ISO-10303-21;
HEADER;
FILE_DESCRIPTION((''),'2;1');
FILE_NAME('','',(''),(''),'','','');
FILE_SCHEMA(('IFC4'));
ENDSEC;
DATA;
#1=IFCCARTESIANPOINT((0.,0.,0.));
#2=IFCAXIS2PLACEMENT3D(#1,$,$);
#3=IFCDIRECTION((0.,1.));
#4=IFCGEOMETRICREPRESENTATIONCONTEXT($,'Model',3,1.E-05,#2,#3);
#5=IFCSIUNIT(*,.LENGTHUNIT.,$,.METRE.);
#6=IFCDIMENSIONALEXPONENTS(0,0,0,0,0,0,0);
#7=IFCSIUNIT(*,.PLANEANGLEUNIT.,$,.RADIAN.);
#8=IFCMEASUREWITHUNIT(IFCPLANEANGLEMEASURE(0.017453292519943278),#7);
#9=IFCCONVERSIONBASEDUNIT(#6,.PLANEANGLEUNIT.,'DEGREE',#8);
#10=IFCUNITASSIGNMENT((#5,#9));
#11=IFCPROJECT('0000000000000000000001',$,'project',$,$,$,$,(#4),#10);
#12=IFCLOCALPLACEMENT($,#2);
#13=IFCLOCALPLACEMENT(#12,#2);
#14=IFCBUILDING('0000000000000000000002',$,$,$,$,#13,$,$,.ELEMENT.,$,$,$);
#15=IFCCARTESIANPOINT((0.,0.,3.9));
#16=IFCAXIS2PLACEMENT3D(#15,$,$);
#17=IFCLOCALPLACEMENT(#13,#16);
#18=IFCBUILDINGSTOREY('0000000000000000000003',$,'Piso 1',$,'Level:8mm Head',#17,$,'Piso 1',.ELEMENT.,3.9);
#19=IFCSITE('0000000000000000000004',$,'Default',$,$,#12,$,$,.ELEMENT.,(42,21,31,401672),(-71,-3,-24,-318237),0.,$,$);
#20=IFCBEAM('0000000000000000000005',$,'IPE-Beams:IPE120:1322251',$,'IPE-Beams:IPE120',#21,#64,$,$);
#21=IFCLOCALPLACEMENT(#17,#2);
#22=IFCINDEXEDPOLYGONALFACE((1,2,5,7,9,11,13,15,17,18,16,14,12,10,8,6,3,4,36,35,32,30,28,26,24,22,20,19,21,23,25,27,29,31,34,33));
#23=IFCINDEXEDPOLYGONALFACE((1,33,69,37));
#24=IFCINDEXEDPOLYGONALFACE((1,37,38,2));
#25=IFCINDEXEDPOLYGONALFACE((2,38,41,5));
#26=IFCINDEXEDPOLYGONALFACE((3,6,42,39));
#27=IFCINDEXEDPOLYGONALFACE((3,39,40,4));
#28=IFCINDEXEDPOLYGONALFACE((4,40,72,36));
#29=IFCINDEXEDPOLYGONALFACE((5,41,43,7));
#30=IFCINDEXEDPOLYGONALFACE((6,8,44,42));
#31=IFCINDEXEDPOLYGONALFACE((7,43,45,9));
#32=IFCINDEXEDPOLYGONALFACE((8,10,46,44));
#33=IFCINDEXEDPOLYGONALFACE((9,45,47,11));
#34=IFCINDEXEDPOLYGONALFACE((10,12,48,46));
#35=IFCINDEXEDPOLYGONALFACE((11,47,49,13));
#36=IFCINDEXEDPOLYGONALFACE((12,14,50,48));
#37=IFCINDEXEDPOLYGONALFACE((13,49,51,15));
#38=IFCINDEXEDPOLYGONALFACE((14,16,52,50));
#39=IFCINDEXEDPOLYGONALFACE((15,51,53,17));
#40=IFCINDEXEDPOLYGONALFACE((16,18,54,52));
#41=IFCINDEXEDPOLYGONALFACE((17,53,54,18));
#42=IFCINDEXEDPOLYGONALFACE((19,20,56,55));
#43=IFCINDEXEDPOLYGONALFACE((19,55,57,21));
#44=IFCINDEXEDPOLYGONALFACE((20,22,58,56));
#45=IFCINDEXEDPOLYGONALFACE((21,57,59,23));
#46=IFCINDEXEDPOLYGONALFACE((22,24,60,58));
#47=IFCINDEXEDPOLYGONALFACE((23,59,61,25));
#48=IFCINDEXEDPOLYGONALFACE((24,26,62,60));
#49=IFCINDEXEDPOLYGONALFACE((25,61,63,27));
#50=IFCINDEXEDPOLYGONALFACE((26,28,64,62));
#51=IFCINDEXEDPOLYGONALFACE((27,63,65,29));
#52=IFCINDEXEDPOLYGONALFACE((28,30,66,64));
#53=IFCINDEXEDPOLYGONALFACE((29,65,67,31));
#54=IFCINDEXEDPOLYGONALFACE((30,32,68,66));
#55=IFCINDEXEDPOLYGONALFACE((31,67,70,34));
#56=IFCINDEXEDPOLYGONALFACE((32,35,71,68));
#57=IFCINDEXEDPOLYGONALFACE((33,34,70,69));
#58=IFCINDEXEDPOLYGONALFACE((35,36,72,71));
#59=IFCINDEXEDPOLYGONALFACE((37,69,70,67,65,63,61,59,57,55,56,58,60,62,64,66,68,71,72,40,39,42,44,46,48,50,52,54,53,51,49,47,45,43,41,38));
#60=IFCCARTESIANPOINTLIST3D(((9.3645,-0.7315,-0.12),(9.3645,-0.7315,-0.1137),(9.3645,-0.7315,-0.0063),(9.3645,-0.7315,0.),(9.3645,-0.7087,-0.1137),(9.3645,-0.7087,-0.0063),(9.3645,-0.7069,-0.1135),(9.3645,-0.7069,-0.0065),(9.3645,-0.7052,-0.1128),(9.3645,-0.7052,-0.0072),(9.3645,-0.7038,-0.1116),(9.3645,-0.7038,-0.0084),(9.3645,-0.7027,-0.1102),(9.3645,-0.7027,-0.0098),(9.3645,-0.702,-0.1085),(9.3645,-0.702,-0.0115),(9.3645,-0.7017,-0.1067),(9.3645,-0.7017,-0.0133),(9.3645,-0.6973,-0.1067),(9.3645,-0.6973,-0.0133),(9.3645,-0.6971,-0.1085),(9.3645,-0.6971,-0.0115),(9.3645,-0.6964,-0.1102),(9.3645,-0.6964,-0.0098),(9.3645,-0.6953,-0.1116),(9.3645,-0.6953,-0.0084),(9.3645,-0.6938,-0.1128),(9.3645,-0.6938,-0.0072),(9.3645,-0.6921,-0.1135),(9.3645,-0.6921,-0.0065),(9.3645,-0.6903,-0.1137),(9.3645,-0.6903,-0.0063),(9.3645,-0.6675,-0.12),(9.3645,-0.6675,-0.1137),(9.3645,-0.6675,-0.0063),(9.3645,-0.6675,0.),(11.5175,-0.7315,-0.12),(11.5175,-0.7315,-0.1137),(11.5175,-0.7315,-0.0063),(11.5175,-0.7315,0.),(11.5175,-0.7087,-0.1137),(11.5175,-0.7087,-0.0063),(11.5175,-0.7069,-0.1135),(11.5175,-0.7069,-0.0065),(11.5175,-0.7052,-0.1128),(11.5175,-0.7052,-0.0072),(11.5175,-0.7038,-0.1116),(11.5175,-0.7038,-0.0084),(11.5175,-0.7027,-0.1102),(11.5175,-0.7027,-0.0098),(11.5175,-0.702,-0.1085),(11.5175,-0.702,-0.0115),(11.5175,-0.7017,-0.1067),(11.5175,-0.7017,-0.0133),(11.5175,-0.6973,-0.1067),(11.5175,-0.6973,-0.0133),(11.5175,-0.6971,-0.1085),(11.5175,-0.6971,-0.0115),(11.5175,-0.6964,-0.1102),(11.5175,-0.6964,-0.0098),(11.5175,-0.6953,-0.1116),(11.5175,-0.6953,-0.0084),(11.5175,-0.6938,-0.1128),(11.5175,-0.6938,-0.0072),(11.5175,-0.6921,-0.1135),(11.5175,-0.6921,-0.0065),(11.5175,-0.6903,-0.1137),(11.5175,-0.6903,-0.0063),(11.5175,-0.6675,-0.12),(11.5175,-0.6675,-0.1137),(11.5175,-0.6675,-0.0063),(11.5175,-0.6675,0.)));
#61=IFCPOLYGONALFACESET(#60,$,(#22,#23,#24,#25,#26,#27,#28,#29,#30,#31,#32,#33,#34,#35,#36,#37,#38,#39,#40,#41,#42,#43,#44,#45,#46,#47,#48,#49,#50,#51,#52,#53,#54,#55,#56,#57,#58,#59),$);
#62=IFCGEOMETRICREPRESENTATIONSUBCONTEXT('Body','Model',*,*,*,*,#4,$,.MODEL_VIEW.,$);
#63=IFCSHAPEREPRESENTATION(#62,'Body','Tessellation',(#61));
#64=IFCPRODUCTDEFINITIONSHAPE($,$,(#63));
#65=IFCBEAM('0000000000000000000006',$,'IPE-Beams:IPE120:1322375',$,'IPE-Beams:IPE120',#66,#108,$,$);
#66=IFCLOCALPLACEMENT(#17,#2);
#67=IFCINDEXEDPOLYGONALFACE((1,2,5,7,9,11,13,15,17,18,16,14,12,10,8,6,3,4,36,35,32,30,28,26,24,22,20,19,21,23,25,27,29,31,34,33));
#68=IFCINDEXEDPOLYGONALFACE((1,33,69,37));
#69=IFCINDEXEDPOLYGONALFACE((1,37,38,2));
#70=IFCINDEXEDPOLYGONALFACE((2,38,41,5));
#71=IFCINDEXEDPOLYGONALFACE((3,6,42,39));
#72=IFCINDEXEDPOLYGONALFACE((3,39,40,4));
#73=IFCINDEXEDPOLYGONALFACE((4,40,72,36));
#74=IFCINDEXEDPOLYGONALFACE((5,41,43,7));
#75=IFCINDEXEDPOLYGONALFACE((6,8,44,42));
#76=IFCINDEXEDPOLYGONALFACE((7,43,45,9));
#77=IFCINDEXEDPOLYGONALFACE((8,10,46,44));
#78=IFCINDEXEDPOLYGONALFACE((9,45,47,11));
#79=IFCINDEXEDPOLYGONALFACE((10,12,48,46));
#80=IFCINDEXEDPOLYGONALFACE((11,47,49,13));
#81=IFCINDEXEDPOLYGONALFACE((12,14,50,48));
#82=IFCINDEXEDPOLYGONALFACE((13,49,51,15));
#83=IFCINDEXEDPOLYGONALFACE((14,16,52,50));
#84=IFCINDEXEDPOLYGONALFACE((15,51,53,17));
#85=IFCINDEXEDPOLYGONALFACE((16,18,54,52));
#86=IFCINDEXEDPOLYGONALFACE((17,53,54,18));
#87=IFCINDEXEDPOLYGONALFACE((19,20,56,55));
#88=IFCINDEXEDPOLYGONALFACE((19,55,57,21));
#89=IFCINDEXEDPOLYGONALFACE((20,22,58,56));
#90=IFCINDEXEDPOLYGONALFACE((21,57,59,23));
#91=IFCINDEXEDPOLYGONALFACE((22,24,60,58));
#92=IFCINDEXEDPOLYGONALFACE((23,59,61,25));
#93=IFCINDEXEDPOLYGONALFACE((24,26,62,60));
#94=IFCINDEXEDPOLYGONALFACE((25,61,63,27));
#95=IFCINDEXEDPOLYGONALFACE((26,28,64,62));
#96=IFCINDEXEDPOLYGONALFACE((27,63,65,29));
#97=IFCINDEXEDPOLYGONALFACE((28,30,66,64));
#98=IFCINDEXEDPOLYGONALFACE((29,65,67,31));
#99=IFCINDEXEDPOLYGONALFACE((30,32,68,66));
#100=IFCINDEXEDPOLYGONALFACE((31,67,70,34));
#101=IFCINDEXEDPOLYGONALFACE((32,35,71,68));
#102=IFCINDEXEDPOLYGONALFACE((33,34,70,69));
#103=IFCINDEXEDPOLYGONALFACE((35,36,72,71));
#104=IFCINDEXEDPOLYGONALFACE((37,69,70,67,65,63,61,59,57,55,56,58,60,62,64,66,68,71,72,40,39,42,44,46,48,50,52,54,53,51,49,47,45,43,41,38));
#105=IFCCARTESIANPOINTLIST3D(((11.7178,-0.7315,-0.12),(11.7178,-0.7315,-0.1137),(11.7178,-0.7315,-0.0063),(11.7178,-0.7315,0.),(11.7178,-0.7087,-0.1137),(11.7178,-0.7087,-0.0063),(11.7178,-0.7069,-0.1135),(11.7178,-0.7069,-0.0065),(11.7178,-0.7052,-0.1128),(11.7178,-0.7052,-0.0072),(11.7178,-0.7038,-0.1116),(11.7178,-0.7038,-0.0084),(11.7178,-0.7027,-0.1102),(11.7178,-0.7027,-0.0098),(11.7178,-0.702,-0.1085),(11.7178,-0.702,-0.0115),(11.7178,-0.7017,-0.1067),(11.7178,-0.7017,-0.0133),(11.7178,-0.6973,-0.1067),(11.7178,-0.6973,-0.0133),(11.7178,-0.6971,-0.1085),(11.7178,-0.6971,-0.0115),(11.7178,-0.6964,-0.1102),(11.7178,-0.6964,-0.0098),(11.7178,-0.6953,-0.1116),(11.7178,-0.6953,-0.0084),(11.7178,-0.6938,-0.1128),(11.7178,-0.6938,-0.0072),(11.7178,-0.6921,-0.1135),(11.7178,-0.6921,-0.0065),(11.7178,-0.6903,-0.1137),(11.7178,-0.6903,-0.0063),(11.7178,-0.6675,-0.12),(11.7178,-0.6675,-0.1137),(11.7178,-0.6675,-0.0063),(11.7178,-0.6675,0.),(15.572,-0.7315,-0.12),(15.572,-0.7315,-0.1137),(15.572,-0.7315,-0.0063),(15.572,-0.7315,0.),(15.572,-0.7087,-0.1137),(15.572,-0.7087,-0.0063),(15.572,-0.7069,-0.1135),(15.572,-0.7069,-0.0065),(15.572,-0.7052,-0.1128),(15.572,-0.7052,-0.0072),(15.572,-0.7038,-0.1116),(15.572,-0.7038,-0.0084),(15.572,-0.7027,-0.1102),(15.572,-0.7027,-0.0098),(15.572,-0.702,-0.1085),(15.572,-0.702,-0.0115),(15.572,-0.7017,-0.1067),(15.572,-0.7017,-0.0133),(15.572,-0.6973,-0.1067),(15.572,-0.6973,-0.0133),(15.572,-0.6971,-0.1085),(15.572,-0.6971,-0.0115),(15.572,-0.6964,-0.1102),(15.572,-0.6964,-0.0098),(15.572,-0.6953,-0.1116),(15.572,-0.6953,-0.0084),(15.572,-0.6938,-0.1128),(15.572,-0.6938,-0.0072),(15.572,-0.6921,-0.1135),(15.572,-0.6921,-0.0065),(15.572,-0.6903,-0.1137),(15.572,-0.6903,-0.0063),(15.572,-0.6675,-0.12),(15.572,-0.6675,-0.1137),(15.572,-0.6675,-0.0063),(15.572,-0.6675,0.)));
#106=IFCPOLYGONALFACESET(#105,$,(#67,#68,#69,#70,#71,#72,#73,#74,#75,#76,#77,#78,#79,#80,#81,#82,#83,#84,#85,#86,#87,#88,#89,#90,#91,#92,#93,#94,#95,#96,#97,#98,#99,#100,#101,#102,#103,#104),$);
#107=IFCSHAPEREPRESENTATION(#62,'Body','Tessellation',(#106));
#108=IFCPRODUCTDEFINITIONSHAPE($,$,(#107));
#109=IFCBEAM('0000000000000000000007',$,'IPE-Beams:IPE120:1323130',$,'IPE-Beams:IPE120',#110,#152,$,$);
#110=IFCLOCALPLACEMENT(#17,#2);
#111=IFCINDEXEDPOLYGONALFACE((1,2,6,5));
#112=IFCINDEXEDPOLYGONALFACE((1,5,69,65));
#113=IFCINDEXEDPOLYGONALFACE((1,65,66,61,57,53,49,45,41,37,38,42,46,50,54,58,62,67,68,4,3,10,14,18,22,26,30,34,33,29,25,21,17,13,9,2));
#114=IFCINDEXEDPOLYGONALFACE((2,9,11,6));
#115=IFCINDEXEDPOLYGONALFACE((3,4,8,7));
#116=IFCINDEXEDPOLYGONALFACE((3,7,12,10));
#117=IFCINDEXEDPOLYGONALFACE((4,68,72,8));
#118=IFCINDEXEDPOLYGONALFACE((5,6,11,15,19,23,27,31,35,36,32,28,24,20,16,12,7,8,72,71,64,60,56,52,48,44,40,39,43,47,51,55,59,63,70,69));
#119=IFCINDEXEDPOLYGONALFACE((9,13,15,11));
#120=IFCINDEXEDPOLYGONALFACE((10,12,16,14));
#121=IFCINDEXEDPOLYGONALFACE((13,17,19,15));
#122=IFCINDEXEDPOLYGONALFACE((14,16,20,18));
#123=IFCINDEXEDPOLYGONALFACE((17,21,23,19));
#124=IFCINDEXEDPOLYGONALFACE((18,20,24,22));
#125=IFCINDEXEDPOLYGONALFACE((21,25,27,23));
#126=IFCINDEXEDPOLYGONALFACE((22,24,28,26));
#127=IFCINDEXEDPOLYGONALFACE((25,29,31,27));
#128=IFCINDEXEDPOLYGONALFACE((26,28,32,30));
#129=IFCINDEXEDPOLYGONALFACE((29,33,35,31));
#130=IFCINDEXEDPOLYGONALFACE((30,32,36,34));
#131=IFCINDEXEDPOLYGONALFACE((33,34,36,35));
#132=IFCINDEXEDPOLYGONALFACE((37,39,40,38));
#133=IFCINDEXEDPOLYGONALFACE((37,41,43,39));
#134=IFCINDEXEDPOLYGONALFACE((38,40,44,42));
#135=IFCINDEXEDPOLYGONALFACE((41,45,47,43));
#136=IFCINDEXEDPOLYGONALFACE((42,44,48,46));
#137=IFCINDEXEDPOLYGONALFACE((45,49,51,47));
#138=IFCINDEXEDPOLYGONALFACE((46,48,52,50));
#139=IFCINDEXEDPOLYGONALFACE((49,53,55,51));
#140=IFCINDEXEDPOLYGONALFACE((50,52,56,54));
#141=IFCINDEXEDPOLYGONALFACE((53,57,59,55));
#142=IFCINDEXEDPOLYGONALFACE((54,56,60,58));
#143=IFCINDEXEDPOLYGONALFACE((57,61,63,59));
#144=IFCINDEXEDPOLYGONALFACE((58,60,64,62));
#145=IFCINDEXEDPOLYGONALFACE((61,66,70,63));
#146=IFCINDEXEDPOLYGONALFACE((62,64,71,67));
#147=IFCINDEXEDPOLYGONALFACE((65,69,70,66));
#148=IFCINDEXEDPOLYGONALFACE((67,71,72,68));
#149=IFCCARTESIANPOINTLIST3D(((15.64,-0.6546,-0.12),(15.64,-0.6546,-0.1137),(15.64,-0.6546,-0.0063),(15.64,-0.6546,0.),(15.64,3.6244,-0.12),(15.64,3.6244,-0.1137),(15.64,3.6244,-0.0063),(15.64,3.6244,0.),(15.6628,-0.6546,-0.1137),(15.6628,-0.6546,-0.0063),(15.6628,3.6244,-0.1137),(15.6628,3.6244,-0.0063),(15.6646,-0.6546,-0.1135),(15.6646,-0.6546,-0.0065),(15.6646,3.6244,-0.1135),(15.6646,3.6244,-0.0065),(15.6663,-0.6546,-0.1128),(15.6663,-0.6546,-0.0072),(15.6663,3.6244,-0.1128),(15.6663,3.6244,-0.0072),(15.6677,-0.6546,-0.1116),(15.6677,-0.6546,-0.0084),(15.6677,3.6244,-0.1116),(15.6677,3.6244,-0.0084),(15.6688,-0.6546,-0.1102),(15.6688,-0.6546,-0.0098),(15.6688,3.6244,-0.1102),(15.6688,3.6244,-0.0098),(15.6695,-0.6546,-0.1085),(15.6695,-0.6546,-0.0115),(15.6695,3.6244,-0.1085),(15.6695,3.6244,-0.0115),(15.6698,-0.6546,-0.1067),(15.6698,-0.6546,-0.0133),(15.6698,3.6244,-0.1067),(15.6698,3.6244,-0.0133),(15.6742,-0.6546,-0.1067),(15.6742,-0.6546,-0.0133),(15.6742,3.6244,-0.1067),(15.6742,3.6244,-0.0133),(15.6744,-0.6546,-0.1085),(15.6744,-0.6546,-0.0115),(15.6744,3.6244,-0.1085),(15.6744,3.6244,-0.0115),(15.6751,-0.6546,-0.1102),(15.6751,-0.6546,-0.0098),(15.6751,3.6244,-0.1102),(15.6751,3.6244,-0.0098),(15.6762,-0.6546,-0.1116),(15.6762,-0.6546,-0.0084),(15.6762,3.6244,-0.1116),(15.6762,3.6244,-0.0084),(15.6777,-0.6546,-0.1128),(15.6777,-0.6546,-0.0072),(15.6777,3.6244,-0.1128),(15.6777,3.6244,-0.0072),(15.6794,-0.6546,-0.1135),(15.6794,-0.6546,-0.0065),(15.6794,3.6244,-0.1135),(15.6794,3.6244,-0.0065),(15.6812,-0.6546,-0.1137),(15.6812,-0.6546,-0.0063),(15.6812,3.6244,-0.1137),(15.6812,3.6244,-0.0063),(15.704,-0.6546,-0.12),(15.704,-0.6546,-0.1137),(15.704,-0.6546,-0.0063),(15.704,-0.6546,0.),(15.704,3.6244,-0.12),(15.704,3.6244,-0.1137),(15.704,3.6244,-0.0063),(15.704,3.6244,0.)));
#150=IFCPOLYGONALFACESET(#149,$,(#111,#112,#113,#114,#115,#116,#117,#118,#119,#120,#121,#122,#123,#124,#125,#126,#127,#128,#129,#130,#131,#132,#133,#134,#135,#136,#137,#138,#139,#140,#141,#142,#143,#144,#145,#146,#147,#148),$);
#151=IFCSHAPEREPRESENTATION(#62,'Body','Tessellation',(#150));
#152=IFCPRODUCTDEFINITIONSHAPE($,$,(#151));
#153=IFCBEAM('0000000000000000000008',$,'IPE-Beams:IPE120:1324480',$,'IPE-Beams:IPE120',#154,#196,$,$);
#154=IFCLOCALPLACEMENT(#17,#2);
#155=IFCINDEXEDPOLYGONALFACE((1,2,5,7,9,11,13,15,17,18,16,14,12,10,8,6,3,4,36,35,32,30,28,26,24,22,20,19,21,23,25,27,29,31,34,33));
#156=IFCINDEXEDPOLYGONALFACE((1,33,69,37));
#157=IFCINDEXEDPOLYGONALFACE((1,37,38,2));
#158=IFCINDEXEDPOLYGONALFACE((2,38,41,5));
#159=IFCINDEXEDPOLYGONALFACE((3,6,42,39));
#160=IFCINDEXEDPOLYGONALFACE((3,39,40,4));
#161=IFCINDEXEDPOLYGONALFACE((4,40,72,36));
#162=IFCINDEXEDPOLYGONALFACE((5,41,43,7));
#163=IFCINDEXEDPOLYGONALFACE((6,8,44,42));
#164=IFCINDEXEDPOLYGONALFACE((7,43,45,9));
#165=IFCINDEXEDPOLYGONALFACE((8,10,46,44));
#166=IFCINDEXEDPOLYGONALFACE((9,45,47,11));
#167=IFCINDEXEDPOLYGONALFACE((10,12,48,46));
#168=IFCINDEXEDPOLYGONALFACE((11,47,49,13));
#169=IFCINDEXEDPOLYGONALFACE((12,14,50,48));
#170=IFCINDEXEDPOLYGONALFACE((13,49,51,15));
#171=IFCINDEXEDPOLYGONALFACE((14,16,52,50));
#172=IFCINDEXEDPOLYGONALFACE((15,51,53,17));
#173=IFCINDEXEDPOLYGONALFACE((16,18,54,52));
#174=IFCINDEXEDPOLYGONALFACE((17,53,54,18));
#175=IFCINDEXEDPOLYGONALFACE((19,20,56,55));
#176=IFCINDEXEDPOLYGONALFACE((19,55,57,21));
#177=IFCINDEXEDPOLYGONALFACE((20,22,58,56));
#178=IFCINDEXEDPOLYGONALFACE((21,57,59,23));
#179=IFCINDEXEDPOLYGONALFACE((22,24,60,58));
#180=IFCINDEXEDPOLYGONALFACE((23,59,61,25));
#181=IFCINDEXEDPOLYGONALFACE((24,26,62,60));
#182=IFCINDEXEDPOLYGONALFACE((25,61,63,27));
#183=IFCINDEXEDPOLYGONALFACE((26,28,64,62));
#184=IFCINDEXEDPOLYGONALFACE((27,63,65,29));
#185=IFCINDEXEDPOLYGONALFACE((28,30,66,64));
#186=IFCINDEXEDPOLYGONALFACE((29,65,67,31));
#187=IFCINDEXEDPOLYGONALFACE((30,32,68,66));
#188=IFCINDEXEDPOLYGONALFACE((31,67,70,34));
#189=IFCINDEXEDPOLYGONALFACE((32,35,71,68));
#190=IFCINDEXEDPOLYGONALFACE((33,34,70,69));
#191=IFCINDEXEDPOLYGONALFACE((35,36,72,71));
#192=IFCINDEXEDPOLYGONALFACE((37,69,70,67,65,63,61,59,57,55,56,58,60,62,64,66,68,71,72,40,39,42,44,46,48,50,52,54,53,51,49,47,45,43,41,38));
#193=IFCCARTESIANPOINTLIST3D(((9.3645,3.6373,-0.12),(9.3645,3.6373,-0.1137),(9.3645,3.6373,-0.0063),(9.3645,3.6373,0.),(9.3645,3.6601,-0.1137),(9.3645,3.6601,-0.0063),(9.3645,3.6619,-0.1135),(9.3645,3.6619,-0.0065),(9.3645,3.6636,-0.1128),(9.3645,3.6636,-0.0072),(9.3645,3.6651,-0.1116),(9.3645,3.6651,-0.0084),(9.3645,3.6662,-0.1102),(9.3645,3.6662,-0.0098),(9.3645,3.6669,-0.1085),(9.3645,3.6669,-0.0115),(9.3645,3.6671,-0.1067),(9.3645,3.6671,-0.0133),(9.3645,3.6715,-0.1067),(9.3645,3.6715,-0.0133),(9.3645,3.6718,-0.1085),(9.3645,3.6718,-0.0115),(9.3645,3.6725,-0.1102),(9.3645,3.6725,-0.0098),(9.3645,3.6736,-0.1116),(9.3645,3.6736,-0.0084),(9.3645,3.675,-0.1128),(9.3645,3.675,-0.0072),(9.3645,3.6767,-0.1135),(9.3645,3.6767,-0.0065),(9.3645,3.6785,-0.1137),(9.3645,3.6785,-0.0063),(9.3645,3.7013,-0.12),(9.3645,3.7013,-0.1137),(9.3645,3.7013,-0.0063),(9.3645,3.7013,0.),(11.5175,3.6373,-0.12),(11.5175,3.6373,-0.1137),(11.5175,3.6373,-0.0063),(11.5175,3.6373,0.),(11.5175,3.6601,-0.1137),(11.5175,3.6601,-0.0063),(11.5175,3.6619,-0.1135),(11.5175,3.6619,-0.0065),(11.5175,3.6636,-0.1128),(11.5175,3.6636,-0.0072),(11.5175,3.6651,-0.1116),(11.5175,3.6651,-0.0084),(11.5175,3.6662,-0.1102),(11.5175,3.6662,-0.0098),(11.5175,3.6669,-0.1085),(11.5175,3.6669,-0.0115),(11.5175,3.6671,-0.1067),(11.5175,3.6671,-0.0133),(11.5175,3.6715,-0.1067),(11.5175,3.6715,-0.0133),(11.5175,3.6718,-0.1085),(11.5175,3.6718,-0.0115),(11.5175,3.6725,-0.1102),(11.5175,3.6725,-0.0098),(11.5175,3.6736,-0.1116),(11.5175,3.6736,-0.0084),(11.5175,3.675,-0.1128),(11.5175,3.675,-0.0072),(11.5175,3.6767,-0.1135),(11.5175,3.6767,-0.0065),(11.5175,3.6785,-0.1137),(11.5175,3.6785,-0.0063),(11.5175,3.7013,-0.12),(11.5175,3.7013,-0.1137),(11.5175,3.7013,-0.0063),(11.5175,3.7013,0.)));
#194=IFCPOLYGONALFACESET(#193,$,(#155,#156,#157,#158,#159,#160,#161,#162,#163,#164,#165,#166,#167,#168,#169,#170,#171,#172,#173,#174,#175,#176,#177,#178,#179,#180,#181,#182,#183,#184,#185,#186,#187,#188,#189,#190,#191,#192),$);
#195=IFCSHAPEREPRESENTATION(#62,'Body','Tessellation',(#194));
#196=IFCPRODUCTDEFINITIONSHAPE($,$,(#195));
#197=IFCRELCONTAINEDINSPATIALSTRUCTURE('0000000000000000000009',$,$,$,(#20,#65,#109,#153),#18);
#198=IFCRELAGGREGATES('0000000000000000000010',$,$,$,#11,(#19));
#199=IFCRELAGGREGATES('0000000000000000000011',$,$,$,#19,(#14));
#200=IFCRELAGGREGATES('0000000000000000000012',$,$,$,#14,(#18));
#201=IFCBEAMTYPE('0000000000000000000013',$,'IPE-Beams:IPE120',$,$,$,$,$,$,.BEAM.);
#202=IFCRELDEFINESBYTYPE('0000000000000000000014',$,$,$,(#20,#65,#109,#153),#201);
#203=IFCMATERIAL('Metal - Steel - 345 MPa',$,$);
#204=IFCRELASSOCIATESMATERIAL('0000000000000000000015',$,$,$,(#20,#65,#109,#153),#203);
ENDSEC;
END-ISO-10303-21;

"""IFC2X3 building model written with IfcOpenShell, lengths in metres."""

from ifc_helpers import new_model, entity, si_unit, converted_unit, direction, frame, frame_2d, origin, place, context, subcontext, project, spatial, i_section, extrude, material, type_object, element, save


model = new_model("IFC2X3")

# Units and contexts
model_context = context("Model", 3, precision=1e-05, world=origin(), true_north=direction((0.0, 1.0)))
body_context = subcontext(model_context, "Body", "Model", "MODEL_VIEW")
ifc_project = project(units=[si_unit("LENGTHUNIT", "METRE"), converted_unit("PLANEANGLEUNIT", "DEGREE", entity("IfcPlaneAngleMeasure", 0.017453292519943278), si_unit("PLANEANGLEUNIT", "RADIAN"), dimensions=[0, 0, 0, 0, 0, 0, 0])], contexts=[model_context])

# Site, building, storey
site_placement = place(None, origin())
site = spatial("IfcSite", under=ifc_project, at=site_placement, Name="Default", CompositionType="ELEMENT", RefLatitude=(42, 21, 31, 401672), RefLongitude=(-71, -3, -24, -318237), RefElevation=0.0)
building_placement = place(site_placement, origin())
building = spatial("IfcBuilding", under=site, at=building_placement, CompositionType="ELEMENT")
storey_placement = place(building_placement, frame((0.0, 0.0, 3.9)))
storey = spatial("IfcBuildingStorey", under=building, at=storey_placement, Name="Piso 1", ObjectType="Level:8mm Head", LongName="Piso 1", CompositionType="ELEMENT", Elevation=3.9)

# Beams
ifc_material = material(Name="Metal - Steel - 345 MPa")
beam_type_1 = type_object("IfcBeamType", Name="IPE-Beams:IPE120", PredefinedType="BEAM")
beam_1_placement = place(storey_placement, frame((11.6176, -0.6995, 0.0), z_axis=(0.0, 0.0, 1.0), x_axis=(-1.0, 0.0, 0.0)))
element("IfcBeam", 1, at=beam_1_placement, inside=storey, type_object=beam_type_1, material=ifc_material, Name="IPE-Beams:IPE120:1322251", ObjectType="IPE-Beams:IPE120", context=body_context, shape_type="SweptSolid", body=[
    extrude(i_section(OverallWidth=0.064, OverallDepth=0.12, WebThickness=0.0044, FlangeThickness=0.0063, FilletRadius=0.007, at=frame_2d((0.0, 0.0), x_axis=(0.0, 1.0))), frame((0.1, 0.0, -0.06), z_axis=(1.0, 0.0, 0.0), x_axis=(0.0, 0.0, -1.0)), (0.0, 0.0, 1.0), 2.153),
])
beam_2_placement = place(storey_placement, frame((11.6176, -0.6995, 0.0)))
element("IfcBeam", 2, at=beam_2_placement, inside=storey, type_object=beam_type_1, material=ifc_material, Name="IPE-Beams:IPE120:1322375", ObjectType="IPE-Beams:IPE120", context=body_context, shape_type="SweptSolid", body=[
    extrude(i_section(OverallWidth=0.064, OverallDepth=0.12, WebThickness=0.0044, FlangeThickness=0.0063, FilletRadius=0.007, at=frame_2d((0.0, 0.0), x_axis=(0.0, 1.0))), frame((0.1002, 0.0, -0.06), z_axis=(1.0, 0.0, 0.0), x_axis=(0.0, 0.0, -1.0)), (0.0, 0.0, 1.0), 3.8542),
])
beam_3_placement = place(storey_placement, frame((15.672, 3.6693, 0.0), z_axis=(0.0, 0.0, 1.0), x_axis=(0.0, -1.0, 0.0)))
element("IfcBeam", 3, at=beam_3_placement, inside=storey, type_object=beam_type_1, material=ifc_material, Name="IPE-Beams:IPE120:1323130", ObjectType="IPE-Beams:IPE120", context=body_context, shape_type="SweptSolid", body=[
    extrude(i_section(OverallWidth=0.064, OverallDepth=0.12, WebThickness=0.0044, FlangeThickness=0.0063, FilletRadius=0.007, at=frame_2d((0.0, 0.0), x_axis=(0.0, 1.0))), frame((0.0449, 0.0, -0.06), z_axis=(1.0, 0.0, 0.0), x_axis=(0.0, 0.0, -1.0)), (0.0, 0.0, 1.0), 4.279),
])
beam_4_placement = place(storey_placement, frame((11.6176, 3.6693, 0.0), z_axis=(0.0, 0.0, 1.0), x_axis=(-1.0, 0.0, 0.0)))
element("IfcBeam", 4, at=beam_4_placement, inside=storey, type_object=beam_type_1, material=ifc_material, Name="IPE-Beams:IPE120:1324480", ObjectType="IPE-Beams:IPE120", context=body_context, shape_type="SweptSolid", body=[
    extrude(i_section(OverallWidth=0.064, OverallDepth=0.12, WebThickness=0.0044, FlangeThickness=0.0063, FilletRadius=0.007, at=frame_2d((0.0, 0.0), x_axis=(0.0, 1.0))), frame((0.1, 0.0, -0.06), z_axis=(1.0, 0.0, 0.0), x_axis=(0.0, 0.0, -1.0)), (0.0, 0.0, 1.0), 2.153),
])

save(model, "model.ifc")
